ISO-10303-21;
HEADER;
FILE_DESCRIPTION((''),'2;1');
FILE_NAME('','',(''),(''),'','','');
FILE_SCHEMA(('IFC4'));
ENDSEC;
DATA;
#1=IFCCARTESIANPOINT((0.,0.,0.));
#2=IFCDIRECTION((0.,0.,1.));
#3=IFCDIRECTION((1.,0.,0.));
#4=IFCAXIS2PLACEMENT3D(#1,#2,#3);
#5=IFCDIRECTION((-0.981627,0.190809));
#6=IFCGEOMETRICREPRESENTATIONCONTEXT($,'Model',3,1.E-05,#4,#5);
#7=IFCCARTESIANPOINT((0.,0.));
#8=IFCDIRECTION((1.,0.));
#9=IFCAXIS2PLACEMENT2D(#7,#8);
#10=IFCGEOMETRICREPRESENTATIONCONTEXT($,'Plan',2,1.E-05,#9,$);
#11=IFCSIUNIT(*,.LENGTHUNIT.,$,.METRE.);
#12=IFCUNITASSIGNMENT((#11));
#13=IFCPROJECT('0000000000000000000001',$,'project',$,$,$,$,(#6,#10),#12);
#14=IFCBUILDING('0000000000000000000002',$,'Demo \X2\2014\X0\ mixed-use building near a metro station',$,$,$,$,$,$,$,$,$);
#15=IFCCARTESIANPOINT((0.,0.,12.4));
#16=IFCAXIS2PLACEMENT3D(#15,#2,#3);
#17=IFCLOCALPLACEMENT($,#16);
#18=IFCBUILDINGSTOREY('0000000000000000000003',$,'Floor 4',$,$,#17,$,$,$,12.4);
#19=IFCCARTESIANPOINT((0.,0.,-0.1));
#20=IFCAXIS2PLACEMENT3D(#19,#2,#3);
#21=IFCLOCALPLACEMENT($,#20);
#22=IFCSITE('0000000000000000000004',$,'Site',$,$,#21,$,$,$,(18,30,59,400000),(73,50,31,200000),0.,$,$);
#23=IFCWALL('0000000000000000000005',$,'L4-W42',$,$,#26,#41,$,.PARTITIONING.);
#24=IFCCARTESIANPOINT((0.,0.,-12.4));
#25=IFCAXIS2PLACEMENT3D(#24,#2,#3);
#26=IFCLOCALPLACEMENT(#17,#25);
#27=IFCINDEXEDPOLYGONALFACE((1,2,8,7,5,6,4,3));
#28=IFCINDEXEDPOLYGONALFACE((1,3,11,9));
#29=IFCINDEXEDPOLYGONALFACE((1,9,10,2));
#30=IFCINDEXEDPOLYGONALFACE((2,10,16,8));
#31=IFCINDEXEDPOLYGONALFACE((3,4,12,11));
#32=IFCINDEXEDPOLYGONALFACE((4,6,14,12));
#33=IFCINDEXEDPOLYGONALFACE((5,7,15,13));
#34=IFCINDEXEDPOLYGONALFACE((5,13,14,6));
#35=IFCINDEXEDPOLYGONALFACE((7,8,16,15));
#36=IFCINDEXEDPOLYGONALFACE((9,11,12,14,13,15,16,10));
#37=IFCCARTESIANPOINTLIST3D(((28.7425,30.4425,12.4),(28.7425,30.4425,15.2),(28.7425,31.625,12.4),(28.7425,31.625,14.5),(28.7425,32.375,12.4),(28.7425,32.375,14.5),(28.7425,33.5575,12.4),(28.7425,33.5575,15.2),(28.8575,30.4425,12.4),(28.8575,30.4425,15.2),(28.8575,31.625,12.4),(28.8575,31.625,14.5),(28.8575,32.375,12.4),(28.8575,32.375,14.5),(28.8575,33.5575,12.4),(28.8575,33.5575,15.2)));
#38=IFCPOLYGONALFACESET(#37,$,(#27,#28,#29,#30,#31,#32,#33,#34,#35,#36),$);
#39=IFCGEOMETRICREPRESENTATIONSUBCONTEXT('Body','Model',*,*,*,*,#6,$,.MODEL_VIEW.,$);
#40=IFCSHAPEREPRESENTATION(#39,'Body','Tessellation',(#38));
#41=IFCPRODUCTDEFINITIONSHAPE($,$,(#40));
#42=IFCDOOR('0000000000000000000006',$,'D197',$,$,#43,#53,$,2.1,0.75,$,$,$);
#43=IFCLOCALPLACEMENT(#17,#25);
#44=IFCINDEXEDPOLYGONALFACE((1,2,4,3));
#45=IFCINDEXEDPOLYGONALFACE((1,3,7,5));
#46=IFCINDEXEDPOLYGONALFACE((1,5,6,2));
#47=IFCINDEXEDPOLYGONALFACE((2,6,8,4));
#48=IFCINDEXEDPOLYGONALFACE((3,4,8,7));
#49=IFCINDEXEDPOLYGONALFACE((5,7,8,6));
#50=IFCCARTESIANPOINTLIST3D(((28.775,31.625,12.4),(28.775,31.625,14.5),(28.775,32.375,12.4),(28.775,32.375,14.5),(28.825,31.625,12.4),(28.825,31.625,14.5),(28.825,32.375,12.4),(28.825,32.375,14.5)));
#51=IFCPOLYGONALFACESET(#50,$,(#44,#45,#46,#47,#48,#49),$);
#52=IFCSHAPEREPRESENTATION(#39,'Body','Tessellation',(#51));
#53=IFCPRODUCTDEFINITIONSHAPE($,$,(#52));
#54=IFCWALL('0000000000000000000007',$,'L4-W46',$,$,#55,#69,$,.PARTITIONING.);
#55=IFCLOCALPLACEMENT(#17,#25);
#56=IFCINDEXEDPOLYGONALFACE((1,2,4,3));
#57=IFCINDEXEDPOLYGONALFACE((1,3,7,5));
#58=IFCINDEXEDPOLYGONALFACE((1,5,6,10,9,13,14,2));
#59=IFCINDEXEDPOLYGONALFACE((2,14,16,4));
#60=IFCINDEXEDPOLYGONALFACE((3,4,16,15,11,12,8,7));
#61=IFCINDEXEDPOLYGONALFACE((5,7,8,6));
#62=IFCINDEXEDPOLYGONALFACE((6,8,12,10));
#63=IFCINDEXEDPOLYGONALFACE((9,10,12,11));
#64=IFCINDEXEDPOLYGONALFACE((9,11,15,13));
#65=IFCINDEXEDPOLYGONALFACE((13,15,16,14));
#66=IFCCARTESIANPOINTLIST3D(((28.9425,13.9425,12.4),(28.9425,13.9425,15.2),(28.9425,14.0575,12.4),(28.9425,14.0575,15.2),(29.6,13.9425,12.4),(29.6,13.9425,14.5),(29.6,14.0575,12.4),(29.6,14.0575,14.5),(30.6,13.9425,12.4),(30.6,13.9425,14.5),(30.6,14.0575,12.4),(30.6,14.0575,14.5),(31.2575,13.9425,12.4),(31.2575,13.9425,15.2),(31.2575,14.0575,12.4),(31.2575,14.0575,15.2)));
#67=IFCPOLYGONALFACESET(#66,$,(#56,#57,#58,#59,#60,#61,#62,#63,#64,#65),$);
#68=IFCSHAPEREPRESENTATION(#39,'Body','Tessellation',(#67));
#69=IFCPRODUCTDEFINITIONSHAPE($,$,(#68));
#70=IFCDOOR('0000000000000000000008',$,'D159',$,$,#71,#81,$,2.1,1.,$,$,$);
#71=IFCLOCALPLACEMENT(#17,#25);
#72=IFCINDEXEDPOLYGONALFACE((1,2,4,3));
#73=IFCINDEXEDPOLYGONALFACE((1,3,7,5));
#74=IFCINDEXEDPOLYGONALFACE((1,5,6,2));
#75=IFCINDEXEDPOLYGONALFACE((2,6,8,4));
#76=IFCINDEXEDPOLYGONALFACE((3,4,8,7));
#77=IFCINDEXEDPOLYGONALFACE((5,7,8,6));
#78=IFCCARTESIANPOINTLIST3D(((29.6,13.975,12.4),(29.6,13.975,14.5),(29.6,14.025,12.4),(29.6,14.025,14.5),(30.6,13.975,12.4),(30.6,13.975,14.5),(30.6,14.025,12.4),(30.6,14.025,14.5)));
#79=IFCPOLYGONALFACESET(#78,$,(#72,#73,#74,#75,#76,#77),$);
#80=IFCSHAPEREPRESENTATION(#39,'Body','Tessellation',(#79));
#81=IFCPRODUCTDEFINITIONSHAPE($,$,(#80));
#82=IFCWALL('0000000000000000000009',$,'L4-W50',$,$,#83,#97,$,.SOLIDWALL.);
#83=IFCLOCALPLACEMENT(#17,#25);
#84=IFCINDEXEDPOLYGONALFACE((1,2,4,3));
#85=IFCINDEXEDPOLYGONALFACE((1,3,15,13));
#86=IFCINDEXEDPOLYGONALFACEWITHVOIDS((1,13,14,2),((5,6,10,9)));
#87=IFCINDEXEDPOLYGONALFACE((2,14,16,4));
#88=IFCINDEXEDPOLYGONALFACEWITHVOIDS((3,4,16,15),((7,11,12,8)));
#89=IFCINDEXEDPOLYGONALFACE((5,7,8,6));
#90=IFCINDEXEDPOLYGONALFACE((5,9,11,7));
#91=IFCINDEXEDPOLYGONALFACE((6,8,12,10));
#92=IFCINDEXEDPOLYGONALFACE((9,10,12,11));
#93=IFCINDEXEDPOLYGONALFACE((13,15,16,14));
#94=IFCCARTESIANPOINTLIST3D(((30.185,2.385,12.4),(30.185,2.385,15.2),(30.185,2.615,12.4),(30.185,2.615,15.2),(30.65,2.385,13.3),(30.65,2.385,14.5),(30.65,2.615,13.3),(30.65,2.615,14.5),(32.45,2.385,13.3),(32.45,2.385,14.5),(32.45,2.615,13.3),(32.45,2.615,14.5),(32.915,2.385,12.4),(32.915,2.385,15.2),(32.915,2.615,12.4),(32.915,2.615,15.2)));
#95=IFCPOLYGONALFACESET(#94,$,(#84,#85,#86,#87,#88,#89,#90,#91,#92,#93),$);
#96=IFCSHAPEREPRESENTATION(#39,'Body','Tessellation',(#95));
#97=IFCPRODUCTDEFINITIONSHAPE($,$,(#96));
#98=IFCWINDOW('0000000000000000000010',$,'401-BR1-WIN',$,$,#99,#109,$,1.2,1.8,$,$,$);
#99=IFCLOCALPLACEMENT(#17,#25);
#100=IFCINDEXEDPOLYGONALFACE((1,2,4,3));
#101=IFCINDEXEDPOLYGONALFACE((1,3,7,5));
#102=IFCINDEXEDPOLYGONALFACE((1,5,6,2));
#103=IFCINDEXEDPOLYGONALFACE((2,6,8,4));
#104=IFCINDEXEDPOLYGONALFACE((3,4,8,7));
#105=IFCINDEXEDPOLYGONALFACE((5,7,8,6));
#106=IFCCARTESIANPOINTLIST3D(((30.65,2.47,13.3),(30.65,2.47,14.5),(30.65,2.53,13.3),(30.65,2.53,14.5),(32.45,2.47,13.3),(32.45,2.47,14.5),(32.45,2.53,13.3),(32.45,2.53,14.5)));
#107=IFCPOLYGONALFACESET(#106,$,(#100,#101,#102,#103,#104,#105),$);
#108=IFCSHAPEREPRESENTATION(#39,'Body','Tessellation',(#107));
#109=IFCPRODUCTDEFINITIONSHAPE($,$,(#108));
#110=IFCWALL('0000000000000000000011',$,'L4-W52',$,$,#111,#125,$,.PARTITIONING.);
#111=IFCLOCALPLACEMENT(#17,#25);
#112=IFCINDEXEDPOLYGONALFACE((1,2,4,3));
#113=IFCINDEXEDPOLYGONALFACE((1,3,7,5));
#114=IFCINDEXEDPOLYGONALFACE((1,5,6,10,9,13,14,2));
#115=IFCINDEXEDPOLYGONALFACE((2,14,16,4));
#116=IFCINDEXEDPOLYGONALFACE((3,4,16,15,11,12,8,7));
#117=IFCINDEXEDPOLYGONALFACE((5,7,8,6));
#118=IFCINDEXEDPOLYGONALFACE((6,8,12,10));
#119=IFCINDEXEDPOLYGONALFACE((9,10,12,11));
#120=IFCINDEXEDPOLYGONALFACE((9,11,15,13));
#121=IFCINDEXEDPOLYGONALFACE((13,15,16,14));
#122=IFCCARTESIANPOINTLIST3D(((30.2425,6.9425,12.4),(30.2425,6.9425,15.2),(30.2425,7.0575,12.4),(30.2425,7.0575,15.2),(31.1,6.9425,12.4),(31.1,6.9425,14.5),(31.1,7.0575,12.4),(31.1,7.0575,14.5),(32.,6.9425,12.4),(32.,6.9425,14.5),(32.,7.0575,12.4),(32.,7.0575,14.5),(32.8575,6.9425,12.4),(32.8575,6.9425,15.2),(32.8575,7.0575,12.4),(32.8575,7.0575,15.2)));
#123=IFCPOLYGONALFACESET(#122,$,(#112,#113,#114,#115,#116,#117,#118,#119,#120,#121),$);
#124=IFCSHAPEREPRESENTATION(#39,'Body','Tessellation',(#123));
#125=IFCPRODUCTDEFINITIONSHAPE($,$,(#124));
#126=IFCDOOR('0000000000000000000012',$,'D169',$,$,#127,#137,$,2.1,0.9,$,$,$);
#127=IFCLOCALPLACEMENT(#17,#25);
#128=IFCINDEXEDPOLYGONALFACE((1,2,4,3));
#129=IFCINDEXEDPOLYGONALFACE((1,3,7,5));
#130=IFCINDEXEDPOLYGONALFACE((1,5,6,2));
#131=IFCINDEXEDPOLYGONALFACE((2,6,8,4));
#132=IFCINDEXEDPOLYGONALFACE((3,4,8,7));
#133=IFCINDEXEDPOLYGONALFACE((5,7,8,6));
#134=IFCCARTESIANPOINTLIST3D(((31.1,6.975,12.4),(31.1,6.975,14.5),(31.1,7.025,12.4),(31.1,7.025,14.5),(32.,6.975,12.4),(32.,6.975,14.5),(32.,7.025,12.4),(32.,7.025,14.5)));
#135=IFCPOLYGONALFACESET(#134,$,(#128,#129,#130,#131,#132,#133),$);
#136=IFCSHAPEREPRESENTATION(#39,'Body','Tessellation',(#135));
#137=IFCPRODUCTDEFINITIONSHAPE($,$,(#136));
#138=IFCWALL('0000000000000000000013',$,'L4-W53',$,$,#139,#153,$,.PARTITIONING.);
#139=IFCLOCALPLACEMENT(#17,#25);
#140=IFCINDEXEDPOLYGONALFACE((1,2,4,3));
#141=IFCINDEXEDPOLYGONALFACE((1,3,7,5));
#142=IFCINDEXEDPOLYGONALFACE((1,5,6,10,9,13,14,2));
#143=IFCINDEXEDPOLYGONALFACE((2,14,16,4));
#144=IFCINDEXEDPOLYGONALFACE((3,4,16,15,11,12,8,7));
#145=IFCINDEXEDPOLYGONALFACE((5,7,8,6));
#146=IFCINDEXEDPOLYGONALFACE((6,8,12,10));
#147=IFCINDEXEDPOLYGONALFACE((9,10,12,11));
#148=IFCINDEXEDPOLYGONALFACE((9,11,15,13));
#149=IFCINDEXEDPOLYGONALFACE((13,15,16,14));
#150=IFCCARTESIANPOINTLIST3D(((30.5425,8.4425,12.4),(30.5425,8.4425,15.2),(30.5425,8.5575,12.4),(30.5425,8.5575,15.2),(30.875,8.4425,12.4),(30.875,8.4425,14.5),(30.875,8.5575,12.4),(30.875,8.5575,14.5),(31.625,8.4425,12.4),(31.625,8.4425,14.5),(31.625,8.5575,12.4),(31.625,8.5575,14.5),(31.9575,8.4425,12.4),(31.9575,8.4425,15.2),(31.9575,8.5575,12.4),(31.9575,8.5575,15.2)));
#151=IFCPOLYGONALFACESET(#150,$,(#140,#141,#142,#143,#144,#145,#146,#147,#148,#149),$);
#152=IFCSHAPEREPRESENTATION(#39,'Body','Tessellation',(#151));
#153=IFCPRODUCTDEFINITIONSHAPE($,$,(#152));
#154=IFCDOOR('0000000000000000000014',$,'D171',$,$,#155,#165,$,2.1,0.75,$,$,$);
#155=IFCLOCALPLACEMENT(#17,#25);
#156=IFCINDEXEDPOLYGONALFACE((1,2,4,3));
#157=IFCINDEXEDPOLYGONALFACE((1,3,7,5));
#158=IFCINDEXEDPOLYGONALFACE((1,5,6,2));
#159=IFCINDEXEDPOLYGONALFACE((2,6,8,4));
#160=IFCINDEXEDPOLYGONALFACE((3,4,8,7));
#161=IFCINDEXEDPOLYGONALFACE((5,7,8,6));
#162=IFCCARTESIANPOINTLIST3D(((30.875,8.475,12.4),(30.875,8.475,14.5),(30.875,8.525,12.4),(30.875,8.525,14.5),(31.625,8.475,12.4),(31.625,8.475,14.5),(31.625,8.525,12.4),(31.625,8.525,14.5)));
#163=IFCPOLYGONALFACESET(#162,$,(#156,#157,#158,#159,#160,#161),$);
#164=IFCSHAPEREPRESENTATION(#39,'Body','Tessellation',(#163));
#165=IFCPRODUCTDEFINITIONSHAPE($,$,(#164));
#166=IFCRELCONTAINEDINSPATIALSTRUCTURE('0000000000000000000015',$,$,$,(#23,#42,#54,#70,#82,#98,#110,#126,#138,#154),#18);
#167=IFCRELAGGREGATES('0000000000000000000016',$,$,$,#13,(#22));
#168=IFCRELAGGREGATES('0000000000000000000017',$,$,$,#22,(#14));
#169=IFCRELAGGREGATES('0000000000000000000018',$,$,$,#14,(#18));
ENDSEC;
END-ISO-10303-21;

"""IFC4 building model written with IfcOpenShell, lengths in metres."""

from ifc_helpers import new_model, si_unit, direction, frame, origin_with_axes, origin_2d_with_axis, place, context, subcontext, project, spatial, line, indexed_curve, outline, extrude, element, fill, save


model = new_model("IFC4")

# Units and contexts
model_context = context("Model", 3, precision=1e-05, world=origin_with_axes(), true_north=direction((-0.981627, 0.190809)))
plan_context = context("Plan", 2, precision=1e-05, world=origin_2d_with_axis())
body_context = subcontext(model_context, "Body", "Model", "MODEL_VIEW")
ifc_project = project(units=[si_unit("LENGTHUNIT", "METRE")], contexts=[model_context, plan_context])

# Site, building, storey
site_placement = place(None, frame((0.0, 0.0, -0.1), z_axis=(0.0, 0.0, 1.0), x_axis=(1.0, 0.0, 0.0)))
site = spatial("IfcSite", under=ifc_project, at=site_placement, Name="Site", RefLatitude=(18, 30, 59, 400000), RefLongitude=(73, 50, 31, 200000), RefElevation=0.0)
building = spatial("IfcBuilding", under=site, Name="Demo — mixed-use building near a metro station")
storey_placement = place(None, frame((0.0, 0.0, 12.4), z_axis=(0.0, 0.0, 1.0), x_axis=(1.0, 0.0, 0.0)))
storey = spatial("IfcBuildingStorey", under=building, at=storey_placement, Name="Floor 4", Elevation=12.4)

# Wall, opening, door
wall_1_placement = place(storey_placement, frame((0.0, 0.0, -12.4), z_axis=(0.0, 0.0, 1.0), x_axis=(1.0, 0.0, 0.0)))
wall_1 = element("IfcWall", 1, at=wall_1_placement, inside=storey, Name="L4-W42", PredefinedType="PARTITIONING", context=body_context, shape_type="SweptSolid", body=[
    extrude(outline(indexed_curve([(28.7425, 30.4425), (28.7425, 33.5575), (28.8575, 33.5575), (28.8575, 30.4425)], segments=[line(1, 2, 3, 4, 1)])), frame((0.0, 0.0, 12.4), z_axis=(0.0, 0.0, 1.0), x_axis=(1.0, 0.0, 0.0)), (0.0, 0.0, 1.0), 2.8),
])
opening_1_placement = place(wall_1_placement, origin_with_axes())
opening_1 = element("IfcOpeningElement", 2, at=opening_1_placement, cuts=wall_1, context=body_context, shape_type="SweptSolid", body=[
    extrude(outline(indexed_curve([(28.6925, 31.625), (28.6925, 32.375), (28.9075, 32.375), (28.9075, 31.625)], segments=[line(1, 2, 3, 4, 1)])), frame((0.0, 0.0, 12.4), z_axis=(0.0, 0.0, 1.0), x_axis=(1.0, 0.0, 0.0)), (0.0, 0.0, 1.0), 2.1),
])
door_1_placement = place(storey_placement, frame((0.0, 0.0, -12.4), z_axis=(0.0, 0.0, 1.0), x_axis=(1.0, 0.0, 0.0)))
door_1 = element("IfcDoor", 3, at=door_1_placement, inside=storey, Name="D197", OverallHeight=2.1, OverallWidth=0.75, context=body_context, shape_type="SweptSolid", body=[
    extrude(outline(indexed_curve([(28.775, 31.625), (28.775, 32.375), (28.825, 32.375), (28.825, 31.625)], segments=[line(1, 2, 3, 4, 1)])), frame((0.0, 0.0, 12.4), z_axis=(0.0, 0.0, 1.0), x_axis=(1.0, 0.0, 0.0)), (0.0, 0.0, 1.0), 2.1),
])
fill(opening_1, door_1)

# Wall, opening, door
wall_2_placement = place(storey_placement, frame((0.0, 0.0, -12.4), z_axis=(0.0, 0.0, 1.0), x_axis=(1.0, 0.0, 0.0)))
wall_2 = element("IfcWall", 4, at=wall_2_placement, inside=storey, Name="L4-W46", PredefinedType="PARTITIONING", context=body_context, shape_type="SweptSolid", body=[
    extrude(outline(indexed_curve([(31.2575, 13.9425), (28.9425, 13.9425), (28.9425, 14.0575), (31.2575, 14.0575)], segments=[line(1, 2, 3, 4, 1)])), frame((0.0, 0.0, 12.4), z_axis=(0.0, 0.0, 1.0), x_axis=(1.0, 0.0, 0.0)), (0.0, 0.0, 1.0), 2.8),
])
opening_2_placement = place(wall_2_placement, origin_with_axes())
opening_2 = element("IfcOpeningElement", 5, at=opening_2_placement, cuts=wall_2, context=body_context, shape_type="SweptSolid", body=[
    extrude(outline(indexed_curve([(30.6, 13.8925), (29.6, 13.8925), (29.6, 14.1075), (30.6, 14.1075)], segments=[line(1, 2, 3, 4, 1)])), frame((0.0, 0.0, 12.4), z_axis=(0.0, 0.0, 1.0), x_axis=(1.0, 0.0, 0.0)), (0.0, 0.0, 1.0), 2.1),
])
door_2_placement = place(storey_placement, frame((0.0, 0.0, -12.4), z_axis=(0.0, 0.0, 1.0), x_axis=(1.0, 0.0, 0.0)))
door_2 = element("IfcDoor", 6, at=door_2_placement, inside=storey, Name="D159", OverallHeight=2.1, OverallWidth=1.0, context=body_context, shape_type="SweptSolid", body=[
    extrude(outline(indexed_curve([(30.6, 13.975), (29.6, 13.975), (29.6, 14.025), (30.6, 14.025)], segments=[line(1, 2, 3, 4, 1)])), frame((0.0, 0.0, 12.4), z_axis=(0.0, 0.0, 1.0), x_axis=(1.0, 0.0, 0.0)), (0.0, 0.0, 1.0), 2.1),
])
fill(opening_2, door_2)

# Wall, opening, window
wall_3_placement = place(storey_placement, frame((0.0, 0.0, -12.4), z_axis=(0.0, 0.0, 1.0), x_axis=(1.0, 0.0, 0.0)))
wall_3 = element("IfcWall", 7, at=wall_3_placement, inside=storey, Name="L4-W50", PredefinedType="SOLIDWALL", context=body_context, shape_type="SweptSolid", body=[
    extrude(outline(indexed_curve([(30.185, 2.615), (32.915, 2.615), (32.915, 2.385), (30.185, 2.385)], segments=[line(1, 2, 3, 4, 1)])), frame((0.0, 0.0, 12.4), z_axis=(0.0, 0.0, 1.0), x_axis=(1.0, 0.0, 0.0)), (0.0, 0.0, 1.0), 2.8),
])
opening_3_placement = place(wall_3_placement, origin_with_axes())
opening_3 = element("IfcOpeningElement", 8, at=opening_3_placement, cuts=wall_3, context=body_context, shape_type="SweptSolid", body=[
    extrude(outline(indexed_curve([(30.65, 2.665), (32.45, 2.665), (32.45, 2.335), (30.65, 2.335)], segments=[line(1, 2, 3, 4, 1)])), frame((0.0, 0.0, 13.3), z_axis=(0.0, 0.0, 1.0), x_axis=(1.0, 0.0, 0.0)), (0.0, 0.0, 1.0), 1.2),
])
window_placement = place(storey_placement, frame((0.0, 0.0, -12.4), z_axis=(0.0, 0.0, 1.0), x_axis=(1.0, 0.0, 0.0)))
window = element("IfcWindow", 9, at=window_placement, inside=storey, Name="401-BR1-WIN", OverallHeight=1.2, OverallWidth=1.8, context=body_context, shape_type="SweptSolid", body=[
    extrude(outline(indexed_curve([(30.65, 2.53), (32.45, 2.53), (32.45, 2.47), (30.65, 2.47)], segments=[line(1, 2, 3, 4, 1)])), frame((0.0, 0.0, 13.3), z_axis=(0.0, 0.0, 1.0), x_axis=(1.0, 0.0, 0.0)), (0.0, 0.0, 1.0), 1.2),
])
fill(opening_3, window)

# Walls, openings, doors
wall_4_placement = place(storey_placement, frame((0.0, 0.0, -12.4), z_axis=(0.0, 0.0, 1.0), x_axis=(1.0, 0.0, 0.0)))
wall_4 = element("IfcWall", 10, at=wall_4_placement, inside=storey, Name="L4-W52", PredefinedType="PARTITIONING", context=body_context, shape_type="SweptSolid", body=[
    extrude(outline(indexed_curve([(32.8575, 6.9425), (30.2425, 6.9425), (30.2425, 7.0575), (32.8575, 7.0575)], segments=[line(1, 2, 3, 4, 1)])), frame((0.0, 0.0, 12.4), z_axis=(0.0, 0.0, 1.0), x_axis=(1.0, 0.0, 0.0)), (0.0, 0.0, 1.0), 2.8),
])
opening_4_placement = place(wall_4_placement, origin_with_axes())
opening_4 = element("IfcOpeningElement", 11, at=opening_4_placement, cuts=wall_4, context=body_context, shape_type="SweptSolid", body=[
    extrude(outline(indexed_curve([(32.0, 6.8925), (31.1, 6.8925), (31.1, 7.1075), (32.0, 7.1075)], segments=[line(1, 2, 3, 4, 1)])), frame((0.0, 0.0, 12.4), z_axis=(0.0, 0.0, 1.0), x_axis=(1.0, 0.0, 0.0)), (0.0, 0.0, 1.0), 2.1),
])
door_3_placement = place(storey_placement, frame((0.0, 0.0, -12.4), z_axis=(0.0, 0.0, 1.0), x_axis=(1.0, 0.0, 0.0)))
door_3 = element("IfcDoor", 12, at=door_3_placement, inside=storey, Name="D169", OverallHeight=2.1, OverallWidth=0.9, context=body_context, shape_type="SweptSolid", body=[
    extrude(outline(indexed_curve([(32.0, 6.975), (31.1, 6.975), (31.1, 7.025), (32.0, 7.025)], segments=[line(1, 2, 3, 4, 1)])), frame((0.0, 0.0, 12.4), z_axis=(0.0, 0.0, 1.0), x_axis=(1.0, 0.0, 0.0)), (0.0, 0.0, 1.0), 2.1),
])
fill(opening_4, door_3)
wall_5_placement = place(storey_placement, frame((0.0, 0.0, -12.4), z_axis=(0.0, 0.0, 1.0), x_axis=(1.0, 0.0, 0.0)))
wall_5 = element("IfcWall", 13, at=wall_5_placement, inside=storey, Name="L4-W53", PredefinedType="PARTITIONING", context=body_context, shape_type="SweptSolid", body=[
    extrude(outline(indexed_curve([(31.9575, 8.4425), (30.5425, 8.4425), (30.5425, 8.5575), (31.9575, 8.5575)], segments=[line(1, 2, 3, 4, 1)])), frame((0.0, 0.0, 12.4), z_axis=(0.0, 0.0, 1.0), x_axis=(1.0, 0.0, 0.0)), (0.0, 0.0, 1.0), 2.8),
])
opening_5_placement = place(wall_5_placement, origin_with_axes())
opening_5 = element("IfcOpeningElement", 14, at=opening_5_placement, cuts=wall_5, context=body_context, shape_type="SweptSolid", body=[
    extrude(outline(indexed_curve([(31.625, 8.3925), (30.875, 8.3925), (30.875, 8.6075), (31.625, 8.6075)], segments=[line(1, 2, 3, 4, 1)])), frame((0.0, 0.0, 12.4), z_axis=(0.0, 0.0, 1.0), x_axis=(1.0, 0.0, 0.0)), (0.0, 0.0, 1.0), 2.1),
])
door_4_placement = place(storey_placement, frame((0.0, 0.0, -12.4), z_axis=(0.0, 0.0, 1.0), x_axis=(1.0, 0.0, 0.0)))
door_4 = element("IfcDoor", 15, at=door_4_placement, inside=storey, Name="D171", OverallHeight=2.1, OverallWidth=0.75, context=body_context, shape_type="SweptSolid", body=[
    extrude(outline(indexed_curve([(31.625, 8.475), (30.875, 8.475), (30.875, 8.525), (31.625, 8.525)], segments=[line(1, 2, 3, 4, 1)])), frame((0.0, 0.0, 12.4), z_axis=(0.0, 0.0, 1.0), x_axis=(1.0, 0.0, 0.0)), (0.0, 0.0, 1.0), 2.1),
])
fill(opening_5, door_4)

save(model, "model.ifc")
